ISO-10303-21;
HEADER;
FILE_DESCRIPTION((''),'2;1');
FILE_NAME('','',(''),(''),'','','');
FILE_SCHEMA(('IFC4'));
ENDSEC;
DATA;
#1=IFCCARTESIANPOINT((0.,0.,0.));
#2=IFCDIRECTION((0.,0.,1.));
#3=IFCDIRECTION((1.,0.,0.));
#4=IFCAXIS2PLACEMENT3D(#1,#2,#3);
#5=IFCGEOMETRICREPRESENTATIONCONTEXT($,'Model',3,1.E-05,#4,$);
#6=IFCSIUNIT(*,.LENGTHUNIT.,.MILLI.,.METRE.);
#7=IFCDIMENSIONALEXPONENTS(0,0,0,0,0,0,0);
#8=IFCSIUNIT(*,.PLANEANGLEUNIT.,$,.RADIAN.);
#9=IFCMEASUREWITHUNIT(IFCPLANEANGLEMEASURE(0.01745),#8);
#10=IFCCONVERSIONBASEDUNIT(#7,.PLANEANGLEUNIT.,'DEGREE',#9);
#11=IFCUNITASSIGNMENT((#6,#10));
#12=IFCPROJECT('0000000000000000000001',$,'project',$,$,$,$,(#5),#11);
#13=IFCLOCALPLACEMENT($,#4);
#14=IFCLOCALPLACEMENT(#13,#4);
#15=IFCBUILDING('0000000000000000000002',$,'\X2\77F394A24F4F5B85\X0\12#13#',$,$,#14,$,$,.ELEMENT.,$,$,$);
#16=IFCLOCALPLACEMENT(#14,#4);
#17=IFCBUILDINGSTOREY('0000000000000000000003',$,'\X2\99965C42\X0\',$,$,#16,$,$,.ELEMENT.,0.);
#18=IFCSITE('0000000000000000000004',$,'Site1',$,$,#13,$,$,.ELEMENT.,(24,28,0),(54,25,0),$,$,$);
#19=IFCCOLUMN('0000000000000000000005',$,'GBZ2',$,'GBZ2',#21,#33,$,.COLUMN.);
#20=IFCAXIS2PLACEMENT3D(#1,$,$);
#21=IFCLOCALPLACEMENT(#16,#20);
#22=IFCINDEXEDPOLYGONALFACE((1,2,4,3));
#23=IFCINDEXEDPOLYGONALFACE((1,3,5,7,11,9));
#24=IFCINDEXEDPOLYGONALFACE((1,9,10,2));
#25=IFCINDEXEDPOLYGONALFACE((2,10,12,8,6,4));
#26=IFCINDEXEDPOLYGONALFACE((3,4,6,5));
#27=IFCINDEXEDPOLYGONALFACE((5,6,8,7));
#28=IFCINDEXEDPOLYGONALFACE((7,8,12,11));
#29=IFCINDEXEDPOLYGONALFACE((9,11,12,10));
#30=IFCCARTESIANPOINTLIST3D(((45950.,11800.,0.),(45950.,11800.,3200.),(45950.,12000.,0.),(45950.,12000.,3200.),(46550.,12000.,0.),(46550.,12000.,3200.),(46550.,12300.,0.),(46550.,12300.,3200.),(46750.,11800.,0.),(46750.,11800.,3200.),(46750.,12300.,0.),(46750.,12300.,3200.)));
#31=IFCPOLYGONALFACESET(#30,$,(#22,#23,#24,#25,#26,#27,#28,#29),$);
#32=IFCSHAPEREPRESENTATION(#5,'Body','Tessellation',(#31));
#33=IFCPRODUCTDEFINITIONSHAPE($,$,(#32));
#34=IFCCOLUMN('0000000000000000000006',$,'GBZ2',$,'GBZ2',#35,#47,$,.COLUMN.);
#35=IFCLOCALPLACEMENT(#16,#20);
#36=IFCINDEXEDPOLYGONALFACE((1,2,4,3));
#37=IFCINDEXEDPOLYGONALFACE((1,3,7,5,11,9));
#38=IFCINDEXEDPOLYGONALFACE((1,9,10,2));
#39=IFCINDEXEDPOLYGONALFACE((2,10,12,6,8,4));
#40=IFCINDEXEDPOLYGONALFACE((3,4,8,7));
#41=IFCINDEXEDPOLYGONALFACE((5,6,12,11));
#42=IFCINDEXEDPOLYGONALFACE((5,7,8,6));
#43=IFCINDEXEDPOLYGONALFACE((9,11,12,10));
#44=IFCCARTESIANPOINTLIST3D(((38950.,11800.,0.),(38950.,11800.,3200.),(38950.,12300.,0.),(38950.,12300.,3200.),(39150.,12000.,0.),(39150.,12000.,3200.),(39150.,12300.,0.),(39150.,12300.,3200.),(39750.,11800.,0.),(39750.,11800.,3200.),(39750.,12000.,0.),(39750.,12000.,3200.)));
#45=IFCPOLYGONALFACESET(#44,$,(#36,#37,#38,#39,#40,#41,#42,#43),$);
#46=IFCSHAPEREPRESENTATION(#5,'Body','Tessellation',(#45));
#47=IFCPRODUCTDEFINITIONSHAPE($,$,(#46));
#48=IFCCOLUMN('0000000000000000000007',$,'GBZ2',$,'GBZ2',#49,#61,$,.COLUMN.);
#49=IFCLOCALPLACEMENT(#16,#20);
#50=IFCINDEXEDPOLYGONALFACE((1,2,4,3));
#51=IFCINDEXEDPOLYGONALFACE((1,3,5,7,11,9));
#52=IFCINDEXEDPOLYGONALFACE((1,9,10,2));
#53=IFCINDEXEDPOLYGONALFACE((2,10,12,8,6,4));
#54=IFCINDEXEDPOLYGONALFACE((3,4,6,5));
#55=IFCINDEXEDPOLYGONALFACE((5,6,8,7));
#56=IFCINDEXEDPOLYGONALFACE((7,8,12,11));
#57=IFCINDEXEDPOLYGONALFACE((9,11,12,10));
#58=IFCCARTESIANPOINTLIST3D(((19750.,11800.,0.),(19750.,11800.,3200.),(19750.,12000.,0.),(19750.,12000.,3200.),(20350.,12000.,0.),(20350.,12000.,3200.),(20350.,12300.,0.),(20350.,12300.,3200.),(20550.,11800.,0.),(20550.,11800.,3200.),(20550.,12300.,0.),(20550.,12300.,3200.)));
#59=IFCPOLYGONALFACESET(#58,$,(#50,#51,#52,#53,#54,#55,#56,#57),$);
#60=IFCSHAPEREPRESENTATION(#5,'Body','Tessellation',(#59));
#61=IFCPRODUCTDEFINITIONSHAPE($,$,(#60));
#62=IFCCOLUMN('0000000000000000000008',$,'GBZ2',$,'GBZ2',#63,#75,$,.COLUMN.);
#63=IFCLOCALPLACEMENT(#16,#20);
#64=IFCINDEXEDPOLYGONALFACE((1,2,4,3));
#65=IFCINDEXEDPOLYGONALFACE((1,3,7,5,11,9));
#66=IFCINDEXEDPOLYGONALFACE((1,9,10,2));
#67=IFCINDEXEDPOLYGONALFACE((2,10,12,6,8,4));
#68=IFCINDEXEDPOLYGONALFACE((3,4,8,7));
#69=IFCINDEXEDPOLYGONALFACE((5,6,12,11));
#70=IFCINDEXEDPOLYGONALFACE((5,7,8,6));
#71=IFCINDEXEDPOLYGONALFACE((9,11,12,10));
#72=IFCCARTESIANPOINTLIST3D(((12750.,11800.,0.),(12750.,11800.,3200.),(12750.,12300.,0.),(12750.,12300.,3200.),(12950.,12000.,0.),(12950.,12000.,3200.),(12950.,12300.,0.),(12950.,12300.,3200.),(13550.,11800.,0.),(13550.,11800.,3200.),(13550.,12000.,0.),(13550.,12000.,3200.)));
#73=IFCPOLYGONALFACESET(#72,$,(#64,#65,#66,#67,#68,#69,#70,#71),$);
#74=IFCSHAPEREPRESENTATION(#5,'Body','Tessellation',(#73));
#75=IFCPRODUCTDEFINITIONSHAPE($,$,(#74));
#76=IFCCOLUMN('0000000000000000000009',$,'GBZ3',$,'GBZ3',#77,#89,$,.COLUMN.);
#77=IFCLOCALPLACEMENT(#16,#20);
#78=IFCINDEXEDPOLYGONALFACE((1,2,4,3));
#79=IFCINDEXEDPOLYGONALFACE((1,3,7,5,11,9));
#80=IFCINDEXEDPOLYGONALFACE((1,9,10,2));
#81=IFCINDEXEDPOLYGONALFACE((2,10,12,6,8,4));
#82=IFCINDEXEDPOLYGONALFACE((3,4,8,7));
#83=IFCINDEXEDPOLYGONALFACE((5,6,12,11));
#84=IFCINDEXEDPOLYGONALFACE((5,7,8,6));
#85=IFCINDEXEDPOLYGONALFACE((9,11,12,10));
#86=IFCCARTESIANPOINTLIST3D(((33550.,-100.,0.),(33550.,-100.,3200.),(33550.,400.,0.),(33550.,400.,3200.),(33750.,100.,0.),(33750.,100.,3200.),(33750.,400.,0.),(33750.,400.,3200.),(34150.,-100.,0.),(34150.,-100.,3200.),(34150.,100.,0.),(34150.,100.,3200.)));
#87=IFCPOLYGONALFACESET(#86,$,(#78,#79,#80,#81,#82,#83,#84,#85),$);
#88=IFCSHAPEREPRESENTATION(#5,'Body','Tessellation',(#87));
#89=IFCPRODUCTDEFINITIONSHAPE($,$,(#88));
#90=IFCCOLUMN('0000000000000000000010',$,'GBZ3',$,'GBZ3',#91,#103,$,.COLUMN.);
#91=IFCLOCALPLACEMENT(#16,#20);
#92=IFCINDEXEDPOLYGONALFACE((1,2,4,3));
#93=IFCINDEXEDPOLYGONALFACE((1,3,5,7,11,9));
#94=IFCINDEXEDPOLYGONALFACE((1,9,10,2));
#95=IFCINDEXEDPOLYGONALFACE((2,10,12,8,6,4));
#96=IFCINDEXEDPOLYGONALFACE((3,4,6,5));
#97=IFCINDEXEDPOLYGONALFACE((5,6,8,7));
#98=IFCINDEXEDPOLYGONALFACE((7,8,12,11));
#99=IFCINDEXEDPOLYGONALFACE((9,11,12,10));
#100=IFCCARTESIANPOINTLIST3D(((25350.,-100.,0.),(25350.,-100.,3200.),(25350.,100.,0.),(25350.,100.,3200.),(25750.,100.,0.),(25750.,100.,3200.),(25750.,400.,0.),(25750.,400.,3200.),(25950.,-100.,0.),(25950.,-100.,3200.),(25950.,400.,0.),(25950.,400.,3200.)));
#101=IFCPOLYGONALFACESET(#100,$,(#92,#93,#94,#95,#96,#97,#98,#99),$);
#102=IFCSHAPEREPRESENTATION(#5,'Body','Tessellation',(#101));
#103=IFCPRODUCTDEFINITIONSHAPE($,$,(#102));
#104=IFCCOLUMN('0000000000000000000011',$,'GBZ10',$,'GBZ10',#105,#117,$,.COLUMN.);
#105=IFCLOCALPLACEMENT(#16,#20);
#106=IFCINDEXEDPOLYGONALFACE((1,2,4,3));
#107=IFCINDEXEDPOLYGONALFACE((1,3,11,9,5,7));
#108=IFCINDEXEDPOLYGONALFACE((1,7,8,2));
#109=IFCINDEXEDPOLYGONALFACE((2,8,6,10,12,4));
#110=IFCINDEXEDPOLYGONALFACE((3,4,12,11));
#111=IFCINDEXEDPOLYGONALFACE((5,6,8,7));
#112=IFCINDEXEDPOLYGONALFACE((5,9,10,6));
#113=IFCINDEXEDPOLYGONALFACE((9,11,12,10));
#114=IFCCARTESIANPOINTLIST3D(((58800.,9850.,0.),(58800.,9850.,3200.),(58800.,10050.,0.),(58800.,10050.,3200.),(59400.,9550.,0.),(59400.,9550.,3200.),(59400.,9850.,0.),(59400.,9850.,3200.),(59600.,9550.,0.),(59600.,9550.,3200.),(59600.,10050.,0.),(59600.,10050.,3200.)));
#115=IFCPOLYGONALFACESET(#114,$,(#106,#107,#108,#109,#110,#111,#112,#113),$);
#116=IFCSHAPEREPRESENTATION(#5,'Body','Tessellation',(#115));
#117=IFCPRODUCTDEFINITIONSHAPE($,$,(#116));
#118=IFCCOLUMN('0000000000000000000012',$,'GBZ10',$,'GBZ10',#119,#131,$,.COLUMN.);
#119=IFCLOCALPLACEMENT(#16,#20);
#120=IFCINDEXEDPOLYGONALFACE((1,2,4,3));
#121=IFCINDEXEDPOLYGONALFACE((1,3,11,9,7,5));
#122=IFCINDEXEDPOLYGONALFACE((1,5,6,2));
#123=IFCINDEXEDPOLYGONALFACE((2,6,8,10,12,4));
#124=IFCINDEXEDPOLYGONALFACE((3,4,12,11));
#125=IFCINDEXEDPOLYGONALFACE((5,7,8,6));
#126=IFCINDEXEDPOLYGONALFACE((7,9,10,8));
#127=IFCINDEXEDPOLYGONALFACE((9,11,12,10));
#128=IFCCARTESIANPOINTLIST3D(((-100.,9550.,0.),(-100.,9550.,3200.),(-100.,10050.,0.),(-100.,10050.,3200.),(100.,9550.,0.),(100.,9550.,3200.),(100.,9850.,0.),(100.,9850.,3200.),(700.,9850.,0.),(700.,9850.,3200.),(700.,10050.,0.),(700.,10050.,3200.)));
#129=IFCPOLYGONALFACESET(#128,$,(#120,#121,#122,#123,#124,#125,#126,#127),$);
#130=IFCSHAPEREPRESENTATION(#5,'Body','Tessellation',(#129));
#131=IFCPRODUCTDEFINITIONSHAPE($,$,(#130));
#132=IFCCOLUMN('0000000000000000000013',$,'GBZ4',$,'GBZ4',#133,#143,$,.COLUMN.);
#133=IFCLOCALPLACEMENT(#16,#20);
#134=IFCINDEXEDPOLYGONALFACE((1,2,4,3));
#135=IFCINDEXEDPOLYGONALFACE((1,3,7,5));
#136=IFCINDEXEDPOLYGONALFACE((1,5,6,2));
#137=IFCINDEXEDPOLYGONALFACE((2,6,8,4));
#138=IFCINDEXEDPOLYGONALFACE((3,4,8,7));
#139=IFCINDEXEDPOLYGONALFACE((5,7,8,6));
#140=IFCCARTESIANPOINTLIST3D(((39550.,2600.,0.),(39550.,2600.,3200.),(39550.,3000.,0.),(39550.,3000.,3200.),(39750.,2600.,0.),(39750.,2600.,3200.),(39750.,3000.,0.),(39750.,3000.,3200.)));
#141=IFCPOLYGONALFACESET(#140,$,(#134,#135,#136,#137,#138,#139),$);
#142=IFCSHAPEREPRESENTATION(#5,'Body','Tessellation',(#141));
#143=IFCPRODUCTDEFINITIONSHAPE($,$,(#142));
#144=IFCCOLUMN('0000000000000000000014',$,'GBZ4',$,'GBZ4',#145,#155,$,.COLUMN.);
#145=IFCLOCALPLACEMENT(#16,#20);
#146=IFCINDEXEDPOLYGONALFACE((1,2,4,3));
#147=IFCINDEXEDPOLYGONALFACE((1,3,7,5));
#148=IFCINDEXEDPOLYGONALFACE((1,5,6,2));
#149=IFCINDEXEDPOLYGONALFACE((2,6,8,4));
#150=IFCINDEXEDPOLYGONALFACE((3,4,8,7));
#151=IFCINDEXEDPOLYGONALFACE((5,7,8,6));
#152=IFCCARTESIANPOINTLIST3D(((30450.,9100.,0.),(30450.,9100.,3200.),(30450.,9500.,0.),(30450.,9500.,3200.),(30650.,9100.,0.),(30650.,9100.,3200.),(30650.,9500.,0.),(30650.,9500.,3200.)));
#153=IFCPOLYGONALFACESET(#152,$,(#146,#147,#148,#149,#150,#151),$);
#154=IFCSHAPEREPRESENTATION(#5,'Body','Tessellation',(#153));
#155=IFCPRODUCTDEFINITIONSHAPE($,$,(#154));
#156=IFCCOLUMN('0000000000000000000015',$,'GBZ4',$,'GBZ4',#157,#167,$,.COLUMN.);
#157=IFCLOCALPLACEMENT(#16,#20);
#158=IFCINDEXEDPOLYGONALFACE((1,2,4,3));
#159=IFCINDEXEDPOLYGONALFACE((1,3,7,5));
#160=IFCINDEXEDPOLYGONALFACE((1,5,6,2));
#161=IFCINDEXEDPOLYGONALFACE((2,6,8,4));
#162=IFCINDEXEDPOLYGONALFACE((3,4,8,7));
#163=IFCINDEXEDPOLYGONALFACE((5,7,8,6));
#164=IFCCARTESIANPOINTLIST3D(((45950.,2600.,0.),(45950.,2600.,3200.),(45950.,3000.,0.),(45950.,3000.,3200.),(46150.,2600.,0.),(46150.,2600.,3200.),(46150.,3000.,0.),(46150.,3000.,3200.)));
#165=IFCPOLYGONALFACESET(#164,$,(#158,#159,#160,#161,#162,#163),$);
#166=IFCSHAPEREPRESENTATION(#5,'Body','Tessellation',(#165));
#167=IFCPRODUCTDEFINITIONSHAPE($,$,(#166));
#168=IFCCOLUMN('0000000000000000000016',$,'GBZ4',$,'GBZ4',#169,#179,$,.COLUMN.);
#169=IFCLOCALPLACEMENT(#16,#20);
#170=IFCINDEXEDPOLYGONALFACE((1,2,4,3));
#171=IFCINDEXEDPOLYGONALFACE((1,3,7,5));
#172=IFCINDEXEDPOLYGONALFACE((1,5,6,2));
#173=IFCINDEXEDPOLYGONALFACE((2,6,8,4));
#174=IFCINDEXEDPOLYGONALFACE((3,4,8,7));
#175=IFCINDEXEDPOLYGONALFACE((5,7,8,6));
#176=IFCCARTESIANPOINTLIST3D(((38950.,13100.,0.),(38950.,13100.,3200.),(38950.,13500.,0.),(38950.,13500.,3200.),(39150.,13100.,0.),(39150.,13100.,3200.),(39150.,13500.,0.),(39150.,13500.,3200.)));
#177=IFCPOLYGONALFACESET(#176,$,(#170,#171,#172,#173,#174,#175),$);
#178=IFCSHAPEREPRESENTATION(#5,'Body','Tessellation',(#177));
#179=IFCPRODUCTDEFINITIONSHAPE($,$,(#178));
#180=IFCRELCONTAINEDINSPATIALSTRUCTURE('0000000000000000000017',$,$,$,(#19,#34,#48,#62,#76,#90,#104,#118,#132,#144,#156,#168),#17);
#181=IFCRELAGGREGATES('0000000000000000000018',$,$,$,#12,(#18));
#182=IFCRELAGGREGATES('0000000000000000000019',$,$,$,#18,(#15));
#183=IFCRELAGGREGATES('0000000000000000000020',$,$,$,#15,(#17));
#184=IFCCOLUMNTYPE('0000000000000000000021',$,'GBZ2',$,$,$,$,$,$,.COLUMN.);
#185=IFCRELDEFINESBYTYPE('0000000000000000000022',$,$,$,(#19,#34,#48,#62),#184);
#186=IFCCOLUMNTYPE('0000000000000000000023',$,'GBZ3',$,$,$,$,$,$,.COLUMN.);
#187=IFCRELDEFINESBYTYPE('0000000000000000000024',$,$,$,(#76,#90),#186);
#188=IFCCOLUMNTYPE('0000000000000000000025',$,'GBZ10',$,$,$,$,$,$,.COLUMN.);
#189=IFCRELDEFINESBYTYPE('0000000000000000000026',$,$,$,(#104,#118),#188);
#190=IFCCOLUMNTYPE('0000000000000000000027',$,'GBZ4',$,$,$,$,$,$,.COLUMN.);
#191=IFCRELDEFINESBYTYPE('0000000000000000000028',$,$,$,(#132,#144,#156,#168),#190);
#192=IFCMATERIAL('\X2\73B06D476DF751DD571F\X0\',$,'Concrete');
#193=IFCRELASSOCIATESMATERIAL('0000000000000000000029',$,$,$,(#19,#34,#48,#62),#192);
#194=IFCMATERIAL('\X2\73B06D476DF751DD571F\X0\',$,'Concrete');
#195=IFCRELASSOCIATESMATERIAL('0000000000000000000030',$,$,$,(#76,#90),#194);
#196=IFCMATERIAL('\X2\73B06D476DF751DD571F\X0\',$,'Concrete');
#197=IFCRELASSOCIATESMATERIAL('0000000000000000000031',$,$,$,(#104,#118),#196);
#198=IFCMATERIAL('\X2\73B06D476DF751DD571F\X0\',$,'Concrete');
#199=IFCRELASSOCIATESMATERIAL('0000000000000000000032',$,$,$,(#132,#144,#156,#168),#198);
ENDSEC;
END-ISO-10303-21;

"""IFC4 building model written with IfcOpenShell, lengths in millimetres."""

from ifc_helpers import new_model, entity, si_unit, converted_unit, frame, origin_with_axes, place, context, project, spatial, polyline, outline, extrude, material, type_object, element, save


model = new_model("IFC4")

# Units and contexts
model_context = context("Model", 3, precision=1e-05, world=origin_with_axes())
ifc_project = project(units=[si_unit("LENGTHUNIT", "METRE", prefix="MILLI"), converted_unit("PLANEANGLEUNIT", "DEGREE", entity("IfcPlaneAngleMeasure", 0.01745), si_unit("PLANEANGLEUNIT", "RADIAN"), dimensions=[0, 0, 0, 0, 0, 0, 0])], contexts=[model_context])

# Site, building, storey
site_placement = place(None, origin_with_axes())
site = spatial("IfcSite", under=ifc_project, at=site_placement, Name="Site1", CompositionType="ELEMENT", RefLatitude=(24, 28, 0), RefLongitude=(54, 25, 0))
building_placement = place(site_placement, origin_with_axes())
building = spatial("IfcBuilding", under=site, at=building_placement, Name="石钢住宅12#13#", CompositionType="ELEMENT")
storey_placement = place(building_placement, origin_with_axes())
storey = spatial("IfcBuildingStorey", under=building, at=storey_placement, Name="首层", CompositionType="ELEMENT", Elevation=0.0)

# Columns
ifc_material_1 = material(Name="现浇混凝土", Category="Concrete")
column_type_1 = type_object("IfcColumnType", Name="GBZ2", PredefinedType="COLUMN")
column_1_placement = place(storey_placement, origin_with_axes())
element("IfcColumn", 1, at=column_1_placement, inside=storey, type_object=column_type_1, material=ifc_material_1, Name="GBZ2", ObjectType="GBZ2", PredefinedType="COLUMN", context=model_context, shape_type="SweptSolid", body=[
    extrude(outline(polyline([(-100.0, -400.0), (100.0, -400.0), (100.0, -100.0), (700.0, -100.0), (700.0, 100.0), (-100.0, 100.0), (-100.0, -400.0)])), frame((46650.0, 11900.0, 0.0), z_axis=(0.0, 0.0, 1.0), x_axis=(-1.0, 0.0, 0.0)), (0.0, 0.0, 1.0), 3200.0),
])
column_2_placement = place(storey_placement, origin_with_axes())
element("IfcColumn", 2, at=column_2_placement, inside=storey, type_object=column_type_1, material=ifc_material_1, Name="GBZ2", ObjectType="GBZ2", PredefinedType="COLUMN", context=model_context, shape_type="SweptSolid", body=[
    extrude(outline(polyline([(100.0, -400.0), (100.0, 100.0), (-700.0, 100.0), (-700.0, -100.0), (-100.0, -100.0), (-100.0, -400.0), (100.0, -400.0)])), frame((39050.0, 11900.0, 0.0), z_axis=(0.0, 0.0, 1.0), x_axis=(-1.0, 0.0, 0.0)), (0.0, 0.0, 1.0), 3200.0),
])
column_3_placement = place(storey_placement, origin_with_axes())
element("IfcColumn", 3, at=column_3_placement, inside=storey, type_object=column_type_1, material=ifc_material_1, Name="GBZ2", ObjectType="GBZ2", PredefinedType="COLUMN", context=model_context, shape_type="SweptSolid", body=[
    extrude(outline(polyline([(100.0, 400.0), (-100.0, 400.0), (-100.0, 100.0), (-700.0, 100.0), (-700.0, -100.0), (100.0, -100.0), (100.0, 400.0)])), frame((20450.0, 11900.0, 0.0), z_axis=(0.0, 0.0, 1.0), x_axis=(1.0, 0.0, 0.0)), (0.0, 0.0, 1.0), 3200.0),
])
column_4_placement = place(storey_placement, origin_with_axes())
element("IfcColumn", 4, at=column_4_placement, inside=storey, type_object=column_type_1, material=ifc_material_1, Name="GBZ2", ObjectType="GBZ2", PredefinedType="COLUMN", context=model_context, shape_type="SweptSolid", body=[
    extrude(outline(polyline([(-100.0, 400.0), (-100.0, -100.0), (700.0, -100.0), (700.0, 100.0), (100.0, 100.0), (100.0, 400.0), (-100.0, 400.0)])), frame((12850.0, 11900.0, 0.0), z_axis=(0.0, 0.0, 1.0), x_axis=(1.0, 0.0, 0.0)), (0.0, 0.0, 1.0), 3200.0),
])
ifc_material_2 = material(Name="现浇混凝土", Category="Concrete")
column_type_2 = type_object("IfcColumnType", Name="GBZ3", PredefinedType="COLUMN")
column_5_placement = place(storey_placement, origin_with_axes())
element("IfcColumn", 5, at=column_5_placement, inside=storey, type_object=column_type_2, material=ifc_material_2, Name="GBZ3", ObjectType="GBZ3", PredefinedType="COLUMN", context=model_context, shape_type="SweptSolid", body=[
    extrude(outline(polyline([(100.0, -400.0), (100.0, 100.0), (-500.0, 100.0), (-500.0, -100.0), (-100.0, -100.0), (-100.0, -400.0), (100.0, -400.0)])), frame((33650.0, 0.0, 0.0), z_axis=(0.0, 0.0, 1.0), x_axis=(-1.0, 0.0, 0.0)), (0.0, 0.0, 1.0), 3200.0),
])
column_6_placement = place(storey_placement, origin_with_axes())
element("IfcColumn", 6, at=column_6_placement, inside=storey, type_object=column_type_2, material=ifc_material_2, Name="GBZ3", ObjectType="GBZ3", PredefinedType="COLUMN", context=model_context, shape_type="SweptSolid", body=[
    extrude(outline(polyline([(100.0, 400.0), (-100.0, 400.0), (-100.0, 100.0), (-500.0, 100.0), (-500.0, -100.0), (100.0, -100.0), (100.0, 400.0)])), frame((25850.0, 0.0, 0.0), z_axis=(0.0, 0.0, 1.0), x_axis=(1.0, 0.0, 0.0)), (0.0, 0.0, 1.0), 3200.0),
])
ifc_material_3 = material(Name="现浇混凝土", Category="Concrete")
column_type_3 = type_object("IfcColumnType", Name="GBZ10", PredefinedType="COLUMN")
column_7_placement = place(storey_placement, origin_with_axes())
element("IfcColumn", 7, at=column_7_placement, inside=storey, type_object=column_type_3, material=ifc_material_3, Name="GBZ10", ObjectType="GBZ10", PredefinedType="COLUMN", context=model_context, shape_type="SweptSolid", body=[
    extrude(outline(polyline([(-100.0, 400.0), (-100.0, -100.0), (700.0, -100.0), (700.0, 100.0), (100.0, 100.0), (100.0, 400.0), (-100.0, 400.0)])), frame((59500.0, 9950.0, 0.0), z_axis=(0.0, 0.0, 1.0), x_axis=(-1.0, 0.0, 0.0)), (0.0, 0.0, 1.0), 3200.0),
])
column_8_placement = place(storey_placement, origin_with_axes())
element("IfcColumn", 8, at=column_8_placement, inside=storey, type_object=column_type_3, material=ifc_material_3, Name="GBZ10", ObjectType="GBZ10", PredefinedType="COLUMN", context=model_context, shape_type="SweptSolid", body=[
    extrude(outline(polyline([(-100.0, -400.0), (100.0, -400.0), (100.0, -100.0), (700.0, -100.0), (700.0, 100.0), (-100.0, 100.0), (-100.0, -400.0)])), frame((0.0, 9950.0, 0.0), z_axis=(0.0, 0.0, 1.0), x_axis=(1.0, 0.0, 0.0)), (0.0, 0.0, 1.0), 3200.0),
])
ifc_material_4 = material(Name="现浇混凝土", Category="Concrete")
column_type_4 = type_object("IfcColumnType", Name="GBZ4", PredefinedType="COLUMN")
column_9_placement = place(storey_placement, origin_with_axes())
element("IfcColumn", 9, at=column_9_placement, inside=storey, type_object=column_type_4, material=ifc_material_4, Name="GBZ4", ObjectType="GBZ4", PredefinedType="COLUMN", context=model_context, shape_type="SweptSolid", body=[
    extrude(outline(polyline([(0.0, 0.0), (400.0, 0.0), (400.0, 200.0), (0.0, 200.0), (0.0, 0.0)])), frame((39750.0, 2600.0, 0.0), z_axis=(0.0, 0.0, 1.0), x_axis=(0.0, 1.0, 0.0)), (0.0, 0.0, 1.0), 3200.0),
])
column_10_placement = place(storey_placement, origin_with_axes())
element("IfcColumn", 10, at=column_10_placement, inside=storey, type_object=column_type_4, material=ifc_material_4, Name="GBZ4", ObjectType="GBZ4", PredefinedType="COLUMN", context=model_context, shape_type="SweptSolid", body=[
    extrude(outline(polyline([(0.0, 0.0), (400.0, 0.0), (400.0, 200.0), (0.0, 200.0), (0.0, 0.0)])), frame((30650.0, 9100.0, 0.0), z_axis=(0.0, 0.0, 1.0), x_axis=(0.0, 1.0, 0.0)), (0.0, 0.0, 1.0), 3200.0),
])
column_11_placement = place(storey_placement, origin_with_axes())
element("IfcColumn", 11, at=column_11_placement, inside=storey, type_object=column_type_4, material=ifc_material_4, Name="GBZ4", ObjectType="GBZ4", PredefinedType="COLUMN", context=model_context, shape_type="SweptSolid", body=[
    extrude(outline(polyline([(0.0, 0.0), (400.0, 0.0), (400.0, 200.0), (0.0, 200.0), (0.0, 0.0)])), frame((46150.0, 2600.0, 0.0), z_axis=(0.0, 0.0, 1.0), x_axis=(0.0, 1.0, 0.0)), (0.0, 0.0, 1.0), 3200.0),
])
column_12_placement = place(storey_placement, origin_with_axes())
element("IfcColumn", 12, at=column_12_placement, inside=storey, type_object=column_type_4, material=ifc_material_4, Name="GBZ4", ObjectType="GBZ4", PredefinedType="COLUMN", context=model_context, shape_type="SweptSolid", body=[
    extrude(outline(polyline([(0.0, 0.0), (400.0, 0.0), (400.0, 200.0), (0.0, 200.0), (0.0, 0.0)])), frame((39150.0, 13100.0, 0.0), z_axis=(0.0, 0.0, 1.0), x_axis=(0.0, 1.0, 0.0)), (0.0, 0.0, 1.0), 3200.0),
])

save(model, "model.ifc")
